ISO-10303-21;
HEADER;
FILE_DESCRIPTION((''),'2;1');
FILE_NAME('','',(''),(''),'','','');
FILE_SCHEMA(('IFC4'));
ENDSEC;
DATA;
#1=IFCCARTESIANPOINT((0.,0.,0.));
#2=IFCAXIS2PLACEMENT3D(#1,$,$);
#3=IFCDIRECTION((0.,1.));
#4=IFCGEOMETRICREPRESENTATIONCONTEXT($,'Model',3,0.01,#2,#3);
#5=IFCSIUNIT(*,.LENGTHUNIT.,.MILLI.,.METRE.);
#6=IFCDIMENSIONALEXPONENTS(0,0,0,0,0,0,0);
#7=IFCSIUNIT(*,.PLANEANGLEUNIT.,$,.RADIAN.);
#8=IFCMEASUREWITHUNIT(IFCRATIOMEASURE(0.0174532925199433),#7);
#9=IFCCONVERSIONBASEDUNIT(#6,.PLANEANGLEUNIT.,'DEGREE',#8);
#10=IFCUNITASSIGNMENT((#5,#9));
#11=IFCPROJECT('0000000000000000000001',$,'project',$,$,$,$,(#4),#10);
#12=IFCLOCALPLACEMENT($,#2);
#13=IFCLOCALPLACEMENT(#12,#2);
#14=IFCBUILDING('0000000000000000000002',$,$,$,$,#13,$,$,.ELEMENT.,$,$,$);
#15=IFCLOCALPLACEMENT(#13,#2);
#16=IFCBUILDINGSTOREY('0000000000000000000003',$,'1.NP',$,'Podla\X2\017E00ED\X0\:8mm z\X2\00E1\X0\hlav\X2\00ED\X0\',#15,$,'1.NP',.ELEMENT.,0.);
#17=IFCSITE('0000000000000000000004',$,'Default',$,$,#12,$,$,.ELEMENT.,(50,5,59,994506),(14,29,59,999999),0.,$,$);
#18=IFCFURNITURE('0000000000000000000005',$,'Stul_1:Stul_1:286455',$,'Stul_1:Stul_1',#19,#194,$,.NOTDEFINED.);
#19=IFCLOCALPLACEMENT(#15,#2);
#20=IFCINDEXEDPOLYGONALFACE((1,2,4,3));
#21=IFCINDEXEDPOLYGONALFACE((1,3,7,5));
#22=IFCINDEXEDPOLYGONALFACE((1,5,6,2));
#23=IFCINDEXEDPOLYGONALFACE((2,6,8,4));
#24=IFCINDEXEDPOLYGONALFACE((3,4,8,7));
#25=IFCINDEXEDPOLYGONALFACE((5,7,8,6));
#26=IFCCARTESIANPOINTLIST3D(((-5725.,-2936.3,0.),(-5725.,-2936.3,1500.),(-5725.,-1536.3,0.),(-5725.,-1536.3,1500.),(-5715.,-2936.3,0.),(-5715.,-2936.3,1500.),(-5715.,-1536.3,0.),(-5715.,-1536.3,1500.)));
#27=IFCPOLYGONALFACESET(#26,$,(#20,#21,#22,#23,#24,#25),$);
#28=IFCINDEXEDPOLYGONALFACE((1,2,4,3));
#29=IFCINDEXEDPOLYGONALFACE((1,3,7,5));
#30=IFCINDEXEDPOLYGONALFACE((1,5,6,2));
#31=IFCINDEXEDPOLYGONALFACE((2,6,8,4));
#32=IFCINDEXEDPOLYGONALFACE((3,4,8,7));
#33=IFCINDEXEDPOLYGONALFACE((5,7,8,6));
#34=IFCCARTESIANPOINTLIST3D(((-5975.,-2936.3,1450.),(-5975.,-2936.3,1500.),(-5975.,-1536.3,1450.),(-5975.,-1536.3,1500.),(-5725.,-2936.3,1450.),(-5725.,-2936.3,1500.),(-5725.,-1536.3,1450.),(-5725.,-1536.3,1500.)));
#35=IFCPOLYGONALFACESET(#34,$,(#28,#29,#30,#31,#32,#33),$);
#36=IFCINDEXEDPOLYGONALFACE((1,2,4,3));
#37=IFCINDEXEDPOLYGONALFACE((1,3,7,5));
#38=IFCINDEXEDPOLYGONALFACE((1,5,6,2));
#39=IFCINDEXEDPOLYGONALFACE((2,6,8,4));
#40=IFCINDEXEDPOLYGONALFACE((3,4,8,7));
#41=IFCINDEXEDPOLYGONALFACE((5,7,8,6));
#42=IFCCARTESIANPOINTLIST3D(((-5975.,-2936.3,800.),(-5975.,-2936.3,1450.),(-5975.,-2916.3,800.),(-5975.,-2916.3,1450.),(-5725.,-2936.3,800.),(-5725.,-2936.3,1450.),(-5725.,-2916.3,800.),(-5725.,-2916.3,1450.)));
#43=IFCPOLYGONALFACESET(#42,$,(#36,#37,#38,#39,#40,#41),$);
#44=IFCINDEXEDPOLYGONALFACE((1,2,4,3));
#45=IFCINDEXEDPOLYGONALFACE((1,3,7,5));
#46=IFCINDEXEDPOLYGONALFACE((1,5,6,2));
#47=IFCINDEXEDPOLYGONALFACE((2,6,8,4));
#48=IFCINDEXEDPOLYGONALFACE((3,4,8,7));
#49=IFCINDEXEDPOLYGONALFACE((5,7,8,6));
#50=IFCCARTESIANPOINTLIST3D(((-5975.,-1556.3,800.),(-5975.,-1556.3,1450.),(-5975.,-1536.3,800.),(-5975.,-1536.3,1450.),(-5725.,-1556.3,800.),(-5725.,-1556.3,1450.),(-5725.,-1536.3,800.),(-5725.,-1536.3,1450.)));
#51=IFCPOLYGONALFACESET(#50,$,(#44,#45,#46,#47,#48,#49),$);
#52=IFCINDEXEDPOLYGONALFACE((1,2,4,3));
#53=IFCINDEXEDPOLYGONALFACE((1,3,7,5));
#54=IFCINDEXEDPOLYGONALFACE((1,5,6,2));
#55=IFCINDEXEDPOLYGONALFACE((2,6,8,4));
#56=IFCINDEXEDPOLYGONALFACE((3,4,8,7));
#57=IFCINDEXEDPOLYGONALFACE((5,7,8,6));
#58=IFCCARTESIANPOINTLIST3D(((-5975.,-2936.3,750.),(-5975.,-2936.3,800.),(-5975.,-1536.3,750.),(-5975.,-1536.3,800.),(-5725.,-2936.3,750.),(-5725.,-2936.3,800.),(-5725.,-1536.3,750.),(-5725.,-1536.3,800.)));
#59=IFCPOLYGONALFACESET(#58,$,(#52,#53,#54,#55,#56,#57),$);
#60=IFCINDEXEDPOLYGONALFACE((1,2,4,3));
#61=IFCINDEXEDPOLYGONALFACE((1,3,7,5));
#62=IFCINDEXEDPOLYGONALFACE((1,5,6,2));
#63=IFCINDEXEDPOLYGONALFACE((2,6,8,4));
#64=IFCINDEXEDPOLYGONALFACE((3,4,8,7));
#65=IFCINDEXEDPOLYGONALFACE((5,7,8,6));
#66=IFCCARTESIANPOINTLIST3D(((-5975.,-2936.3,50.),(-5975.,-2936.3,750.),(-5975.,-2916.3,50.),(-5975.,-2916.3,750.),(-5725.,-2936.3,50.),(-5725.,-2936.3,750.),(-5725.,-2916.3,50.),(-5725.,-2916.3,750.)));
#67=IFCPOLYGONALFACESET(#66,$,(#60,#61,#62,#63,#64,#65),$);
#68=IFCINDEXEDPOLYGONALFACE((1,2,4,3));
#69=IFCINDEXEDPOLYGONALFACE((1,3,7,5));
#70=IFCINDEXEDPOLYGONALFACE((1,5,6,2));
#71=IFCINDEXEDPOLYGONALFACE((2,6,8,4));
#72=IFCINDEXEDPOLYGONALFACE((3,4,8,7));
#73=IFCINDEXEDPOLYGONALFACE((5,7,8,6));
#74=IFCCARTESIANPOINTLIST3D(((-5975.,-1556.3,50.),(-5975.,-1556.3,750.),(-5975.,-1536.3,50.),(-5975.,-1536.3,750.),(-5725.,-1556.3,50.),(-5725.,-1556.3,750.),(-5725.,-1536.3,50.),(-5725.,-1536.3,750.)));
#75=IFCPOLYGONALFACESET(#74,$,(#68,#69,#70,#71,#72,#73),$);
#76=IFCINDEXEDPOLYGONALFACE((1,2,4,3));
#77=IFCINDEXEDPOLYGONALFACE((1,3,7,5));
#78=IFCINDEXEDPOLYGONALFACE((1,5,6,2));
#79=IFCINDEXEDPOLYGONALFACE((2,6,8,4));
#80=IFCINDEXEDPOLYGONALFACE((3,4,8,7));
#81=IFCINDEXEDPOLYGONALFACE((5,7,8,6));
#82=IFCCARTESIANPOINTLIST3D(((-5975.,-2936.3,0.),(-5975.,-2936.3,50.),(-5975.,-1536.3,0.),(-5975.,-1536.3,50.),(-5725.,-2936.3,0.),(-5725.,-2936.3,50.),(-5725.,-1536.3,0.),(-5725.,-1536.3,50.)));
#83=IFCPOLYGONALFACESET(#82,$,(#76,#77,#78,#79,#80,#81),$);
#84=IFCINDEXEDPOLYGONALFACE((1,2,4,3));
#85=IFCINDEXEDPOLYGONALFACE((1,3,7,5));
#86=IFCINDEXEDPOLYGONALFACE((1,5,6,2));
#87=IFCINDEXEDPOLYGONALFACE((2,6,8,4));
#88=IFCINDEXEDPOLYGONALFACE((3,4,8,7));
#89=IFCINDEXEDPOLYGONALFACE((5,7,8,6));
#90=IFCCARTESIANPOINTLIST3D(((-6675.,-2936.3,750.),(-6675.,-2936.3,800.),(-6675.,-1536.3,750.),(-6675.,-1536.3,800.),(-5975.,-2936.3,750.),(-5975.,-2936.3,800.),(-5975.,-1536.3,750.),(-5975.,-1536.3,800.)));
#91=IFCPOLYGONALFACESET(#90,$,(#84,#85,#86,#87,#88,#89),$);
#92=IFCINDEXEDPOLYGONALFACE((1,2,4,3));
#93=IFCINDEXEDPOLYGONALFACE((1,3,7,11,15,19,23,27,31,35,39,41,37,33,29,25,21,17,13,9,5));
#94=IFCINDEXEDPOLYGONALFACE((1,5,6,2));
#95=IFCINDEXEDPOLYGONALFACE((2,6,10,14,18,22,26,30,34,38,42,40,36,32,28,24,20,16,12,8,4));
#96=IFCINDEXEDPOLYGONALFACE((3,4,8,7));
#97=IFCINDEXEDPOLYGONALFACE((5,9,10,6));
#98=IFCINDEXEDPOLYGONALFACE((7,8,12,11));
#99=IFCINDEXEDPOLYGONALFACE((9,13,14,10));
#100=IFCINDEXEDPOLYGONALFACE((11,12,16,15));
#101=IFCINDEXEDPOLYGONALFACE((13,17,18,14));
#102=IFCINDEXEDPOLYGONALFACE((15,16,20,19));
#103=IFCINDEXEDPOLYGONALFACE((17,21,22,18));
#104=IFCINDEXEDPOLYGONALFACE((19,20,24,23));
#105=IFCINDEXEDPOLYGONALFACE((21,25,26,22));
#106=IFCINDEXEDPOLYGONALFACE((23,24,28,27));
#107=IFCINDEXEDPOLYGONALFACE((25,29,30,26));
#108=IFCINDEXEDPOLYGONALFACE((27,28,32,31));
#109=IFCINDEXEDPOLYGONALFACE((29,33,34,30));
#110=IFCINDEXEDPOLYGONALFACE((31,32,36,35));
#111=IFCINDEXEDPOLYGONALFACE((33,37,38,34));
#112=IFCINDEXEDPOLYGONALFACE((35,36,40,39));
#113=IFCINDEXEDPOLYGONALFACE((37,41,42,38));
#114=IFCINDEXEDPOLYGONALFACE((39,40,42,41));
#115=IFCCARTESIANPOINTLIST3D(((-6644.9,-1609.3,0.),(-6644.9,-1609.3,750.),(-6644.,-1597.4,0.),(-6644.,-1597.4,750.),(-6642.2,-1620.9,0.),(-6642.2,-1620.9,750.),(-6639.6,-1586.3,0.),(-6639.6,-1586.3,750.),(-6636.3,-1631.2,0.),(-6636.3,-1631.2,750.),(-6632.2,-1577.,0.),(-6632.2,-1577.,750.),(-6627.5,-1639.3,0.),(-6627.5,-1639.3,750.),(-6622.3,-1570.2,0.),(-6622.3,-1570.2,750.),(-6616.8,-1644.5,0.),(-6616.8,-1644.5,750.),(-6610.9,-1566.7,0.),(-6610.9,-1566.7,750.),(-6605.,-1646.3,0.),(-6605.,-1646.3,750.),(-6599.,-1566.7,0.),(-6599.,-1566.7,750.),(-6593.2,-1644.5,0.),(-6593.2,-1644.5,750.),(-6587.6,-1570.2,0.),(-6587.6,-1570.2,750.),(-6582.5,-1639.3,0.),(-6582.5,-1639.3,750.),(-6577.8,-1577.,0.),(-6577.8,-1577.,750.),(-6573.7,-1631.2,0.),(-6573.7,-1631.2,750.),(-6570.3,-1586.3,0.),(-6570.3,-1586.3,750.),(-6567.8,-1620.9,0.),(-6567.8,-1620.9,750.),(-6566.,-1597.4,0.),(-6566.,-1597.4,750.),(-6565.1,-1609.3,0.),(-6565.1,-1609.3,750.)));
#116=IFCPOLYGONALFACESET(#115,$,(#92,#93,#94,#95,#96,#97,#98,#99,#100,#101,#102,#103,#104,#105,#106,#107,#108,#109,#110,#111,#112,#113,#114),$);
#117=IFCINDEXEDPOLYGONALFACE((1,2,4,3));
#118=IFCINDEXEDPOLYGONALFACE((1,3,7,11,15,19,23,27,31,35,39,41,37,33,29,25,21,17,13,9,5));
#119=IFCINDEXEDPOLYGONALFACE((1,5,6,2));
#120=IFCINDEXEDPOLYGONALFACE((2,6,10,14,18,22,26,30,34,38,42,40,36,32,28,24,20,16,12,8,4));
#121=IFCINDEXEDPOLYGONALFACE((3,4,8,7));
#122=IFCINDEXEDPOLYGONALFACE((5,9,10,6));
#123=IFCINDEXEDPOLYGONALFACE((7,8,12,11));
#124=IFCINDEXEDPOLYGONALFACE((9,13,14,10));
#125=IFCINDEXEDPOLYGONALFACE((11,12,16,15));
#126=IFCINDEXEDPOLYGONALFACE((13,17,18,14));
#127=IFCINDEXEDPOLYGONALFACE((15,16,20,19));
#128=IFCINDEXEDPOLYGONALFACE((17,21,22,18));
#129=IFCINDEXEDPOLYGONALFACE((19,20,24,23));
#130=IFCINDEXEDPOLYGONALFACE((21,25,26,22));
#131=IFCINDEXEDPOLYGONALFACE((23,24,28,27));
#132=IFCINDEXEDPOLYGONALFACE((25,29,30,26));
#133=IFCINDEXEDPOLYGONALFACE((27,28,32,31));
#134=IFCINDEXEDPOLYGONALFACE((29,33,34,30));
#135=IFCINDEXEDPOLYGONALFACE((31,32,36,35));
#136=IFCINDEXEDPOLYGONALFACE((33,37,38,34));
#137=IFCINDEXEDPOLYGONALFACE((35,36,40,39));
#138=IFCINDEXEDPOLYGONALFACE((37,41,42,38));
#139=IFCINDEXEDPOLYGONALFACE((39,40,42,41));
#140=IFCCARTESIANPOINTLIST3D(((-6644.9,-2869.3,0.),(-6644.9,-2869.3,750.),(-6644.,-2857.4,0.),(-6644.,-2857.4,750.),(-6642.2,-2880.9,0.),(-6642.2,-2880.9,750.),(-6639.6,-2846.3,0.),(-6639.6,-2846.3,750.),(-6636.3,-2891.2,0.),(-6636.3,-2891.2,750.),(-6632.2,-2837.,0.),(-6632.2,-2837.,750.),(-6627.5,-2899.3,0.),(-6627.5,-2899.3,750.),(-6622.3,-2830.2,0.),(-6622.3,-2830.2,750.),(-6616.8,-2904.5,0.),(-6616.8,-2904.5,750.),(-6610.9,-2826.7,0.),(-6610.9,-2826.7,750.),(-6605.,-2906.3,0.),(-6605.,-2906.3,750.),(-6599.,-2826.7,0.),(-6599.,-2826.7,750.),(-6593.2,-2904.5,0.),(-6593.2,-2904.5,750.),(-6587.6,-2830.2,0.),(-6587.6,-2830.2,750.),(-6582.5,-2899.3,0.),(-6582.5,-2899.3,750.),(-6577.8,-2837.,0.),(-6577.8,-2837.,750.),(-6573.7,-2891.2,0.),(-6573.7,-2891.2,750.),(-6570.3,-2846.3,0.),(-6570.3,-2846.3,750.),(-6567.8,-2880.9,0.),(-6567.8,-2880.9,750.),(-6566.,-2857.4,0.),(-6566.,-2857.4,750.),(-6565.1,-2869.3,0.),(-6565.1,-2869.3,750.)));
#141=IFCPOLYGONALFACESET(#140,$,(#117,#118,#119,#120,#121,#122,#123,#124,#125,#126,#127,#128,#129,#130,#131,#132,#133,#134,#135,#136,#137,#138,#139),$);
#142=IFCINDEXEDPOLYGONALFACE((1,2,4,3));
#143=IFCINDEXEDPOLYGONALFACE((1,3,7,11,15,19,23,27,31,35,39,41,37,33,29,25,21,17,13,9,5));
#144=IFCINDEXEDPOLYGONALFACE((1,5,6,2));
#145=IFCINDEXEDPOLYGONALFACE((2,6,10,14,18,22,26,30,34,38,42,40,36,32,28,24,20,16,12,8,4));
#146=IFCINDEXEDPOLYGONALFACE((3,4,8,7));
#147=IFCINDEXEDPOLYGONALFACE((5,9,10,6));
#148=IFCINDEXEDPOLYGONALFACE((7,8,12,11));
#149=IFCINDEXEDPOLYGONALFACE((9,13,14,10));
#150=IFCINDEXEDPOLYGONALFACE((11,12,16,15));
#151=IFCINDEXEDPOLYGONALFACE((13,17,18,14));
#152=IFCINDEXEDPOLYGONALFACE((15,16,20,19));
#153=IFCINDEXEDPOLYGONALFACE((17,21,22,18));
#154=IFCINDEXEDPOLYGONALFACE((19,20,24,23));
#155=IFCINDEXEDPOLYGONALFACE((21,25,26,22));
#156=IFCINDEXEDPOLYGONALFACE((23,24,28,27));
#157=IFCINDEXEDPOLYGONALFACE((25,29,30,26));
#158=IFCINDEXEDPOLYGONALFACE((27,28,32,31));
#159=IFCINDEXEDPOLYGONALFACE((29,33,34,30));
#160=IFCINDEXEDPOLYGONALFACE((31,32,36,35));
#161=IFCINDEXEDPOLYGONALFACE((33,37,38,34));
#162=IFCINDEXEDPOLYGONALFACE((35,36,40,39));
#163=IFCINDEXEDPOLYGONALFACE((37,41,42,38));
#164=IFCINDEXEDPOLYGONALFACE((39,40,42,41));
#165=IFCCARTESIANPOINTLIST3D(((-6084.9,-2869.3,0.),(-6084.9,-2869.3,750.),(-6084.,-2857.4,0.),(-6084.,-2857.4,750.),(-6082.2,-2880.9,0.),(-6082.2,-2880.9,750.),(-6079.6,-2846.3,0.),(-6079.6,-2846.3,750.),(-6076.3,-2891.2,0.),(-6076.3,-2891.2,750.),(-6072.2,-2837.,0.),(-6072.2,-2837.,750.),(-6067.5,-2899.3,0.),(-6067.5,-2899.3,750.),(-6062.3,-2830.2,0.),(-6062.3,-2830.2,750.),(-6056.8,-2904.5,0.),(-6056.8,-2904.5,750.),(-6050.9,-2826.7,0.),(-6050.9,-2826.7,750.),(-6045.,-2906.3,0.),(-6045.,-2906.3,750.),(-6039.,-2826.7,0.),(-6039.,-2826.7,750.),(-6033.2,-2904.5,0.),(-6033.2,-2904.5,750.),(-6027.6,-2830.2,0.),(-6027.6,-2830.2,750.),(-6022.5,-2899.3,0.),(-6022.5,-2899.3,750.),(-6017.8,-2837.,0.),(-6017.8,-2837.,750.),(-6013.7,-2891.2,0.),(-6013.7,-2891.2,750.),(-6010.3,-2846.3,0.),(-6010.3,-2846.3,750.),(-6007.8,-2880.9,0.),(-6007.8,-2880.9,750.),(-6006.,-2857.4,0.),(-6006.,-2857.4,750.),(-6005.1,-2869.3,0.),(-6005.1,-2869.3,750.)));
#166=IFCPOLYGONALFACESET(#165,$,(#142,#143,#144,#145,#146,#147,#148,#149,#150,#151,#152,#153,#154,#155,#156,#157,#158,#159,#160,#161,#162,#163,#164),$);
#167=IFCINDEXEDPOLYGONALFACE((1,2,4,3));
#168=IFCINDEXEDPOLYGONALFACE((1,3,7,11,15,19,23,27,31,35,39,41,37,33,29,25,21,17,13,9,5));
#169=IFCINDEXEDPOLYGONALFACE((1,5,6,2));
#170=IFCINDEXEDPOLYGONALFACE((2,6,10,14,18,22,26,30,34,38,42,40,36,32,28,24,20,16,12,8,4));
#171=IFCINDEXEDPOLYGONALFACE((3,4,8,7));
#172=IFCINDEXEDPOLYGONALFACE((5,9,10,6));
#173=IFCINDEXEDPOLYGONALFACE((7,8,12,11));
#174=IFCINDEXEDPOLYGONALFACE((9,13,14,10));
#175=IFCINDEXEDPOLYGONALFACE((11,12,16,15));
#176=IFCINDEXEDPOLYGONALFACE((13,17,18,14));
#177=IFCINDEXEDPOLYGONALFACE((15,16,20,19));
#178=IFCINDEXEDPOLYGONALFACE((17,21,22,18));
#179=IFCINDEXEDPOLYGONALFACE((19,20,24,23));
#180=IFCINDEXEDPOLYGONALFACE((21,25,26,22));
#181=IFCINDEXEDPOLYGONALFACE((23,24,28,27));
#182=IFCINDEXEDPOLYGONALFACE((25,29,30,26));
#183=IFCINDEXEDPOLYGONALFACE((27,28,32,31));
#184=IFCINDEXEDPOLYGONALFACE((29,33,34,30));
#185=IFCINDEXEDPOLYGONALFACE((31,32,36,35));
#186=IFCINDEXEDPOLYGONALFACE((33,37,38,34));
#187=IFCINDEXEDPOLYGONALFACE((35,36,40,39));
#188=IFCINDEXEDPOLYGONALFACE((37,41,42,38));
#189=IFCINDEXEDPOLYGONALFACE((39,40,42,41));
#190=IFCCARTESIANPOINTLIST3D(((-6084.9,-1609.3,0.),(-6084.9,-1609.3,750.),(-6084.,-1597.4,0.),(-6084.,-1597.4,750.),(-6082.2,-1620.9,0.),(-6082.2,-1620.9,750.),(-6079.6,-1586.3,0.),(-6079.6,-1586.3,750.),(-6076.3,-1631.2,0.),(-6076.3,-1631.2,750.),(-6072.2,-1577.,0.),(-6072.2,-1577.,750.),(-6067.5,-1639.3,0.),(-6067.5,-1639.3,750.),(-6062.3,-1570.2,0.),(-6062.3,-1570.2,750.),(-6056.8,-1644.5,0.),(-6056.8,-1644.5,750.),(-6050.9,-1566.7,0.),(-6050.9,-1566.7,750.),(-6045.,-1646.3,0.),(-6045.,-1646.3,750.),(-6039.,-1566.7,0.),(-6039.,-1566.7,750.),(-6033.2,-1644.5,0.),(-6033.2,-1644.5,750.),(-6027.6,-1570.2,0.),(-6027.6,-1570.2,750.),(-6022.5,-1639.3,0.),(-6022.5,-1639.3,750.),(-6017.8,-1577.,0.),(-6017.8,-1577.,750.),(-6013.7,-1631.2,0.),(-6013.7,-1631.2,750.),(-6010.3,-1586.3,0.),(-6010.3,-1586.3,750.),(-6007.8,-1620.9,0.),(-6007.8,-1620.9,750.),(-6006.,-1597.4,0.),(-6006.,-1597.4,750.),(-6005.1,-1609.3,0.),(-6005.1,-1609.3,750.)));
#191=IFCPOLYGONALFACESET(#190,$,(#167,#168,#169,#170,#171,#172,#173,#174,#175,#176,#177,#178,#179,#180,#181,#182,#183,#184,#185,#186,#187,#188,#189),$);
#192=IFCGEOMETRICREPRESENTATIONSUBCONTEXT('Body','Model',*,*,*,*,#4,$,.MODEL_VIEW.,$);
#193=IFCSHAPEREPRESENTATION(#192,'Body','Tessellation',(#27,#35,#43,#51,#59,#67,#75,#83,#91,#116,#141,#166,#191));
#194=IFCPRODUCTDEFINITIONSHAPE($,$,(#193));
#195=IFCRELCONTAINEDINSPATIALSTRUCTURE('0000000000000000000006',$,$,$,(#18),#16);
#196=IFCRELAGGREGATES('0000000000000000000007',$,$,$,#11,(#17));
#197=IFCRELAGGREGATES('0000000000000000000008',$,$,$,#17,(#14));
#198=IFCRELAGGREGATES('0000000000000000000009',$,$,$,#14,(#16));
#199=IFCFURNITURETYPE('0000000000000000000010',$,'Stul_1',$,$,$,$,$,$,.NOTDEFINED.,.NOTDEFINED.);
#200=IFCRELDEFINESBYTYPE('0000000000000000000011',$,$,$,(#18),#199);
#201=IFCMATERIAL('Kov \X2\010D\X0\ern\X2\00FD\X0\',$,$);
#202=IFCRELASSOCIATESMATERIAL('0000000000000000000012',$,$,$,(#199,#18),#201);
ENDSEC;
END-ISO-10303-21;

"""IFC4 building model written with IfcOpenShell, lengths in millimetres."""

from ifc_helpers import new_model, entity, si_unit, converted_unit, direction, frame, frame_2d, origin, origin_2d_with_axis, place, context, subcontext, project, spatial, rectangle, circle, extrude, source, transform, mapped, material, type_object, type_shapes, element, save


model = new_model("IFC4")

# Units and contexts
model_context = context("Model", 3, precision=0.01, world=origin(), true_north=direction((0.0, 1.0)))
body_context = subcontext(model_context, "Body", "Model", "MODEL_VIEW")
ifc_project = project(units=[si_unit("LENGTHUNIT", "METRE", prefix="MILLI"), converted_unit("PLANEANGLEUNIT", "DEGREE", entity("IfcRatioMeasure", 0.0174532925199433), si_unit("PLANEANGLEUNIT", "RADIAN"), dimensions=[0, 0, 0, 0, 0, 0, 0])], contexts=[model_context])

# Site, building, storey
site_placement = place(None, origin())
site = spatial("IfcSite", under=ifc_project, at=site_placement, Name="Default", CompositionType="ELEMENT", RefLatitude=(50, 5, 59, 994506), RefLongitude=(14, 29, 59, 999999), RefElevation=0.0)
building_placement = place(site_placement, origin())
building = spatial("IfcBuilding", under=site, at=building_placement, CompositionType="ELEMENT")
storey_placement = place(building_placement, origin())
storey = spatial("IfcBuildingStorey", under=building, at=storey_placement, Name="1.NP", ObjectType="Podlaží:8mm záhlaví", LongName="1.NP", CompositionType="ELEMENT", Elevation=0.0)

# Furniture
ifc_material_1 = material(Name="Kov černý")
furniture_type = type_object("IfcFurnitureType", Name="Stul_1", AssemblyPlace="NOTDEFINED", PredefinedType="NOTDEFINED", material=ifc_material_1)
shared_shape_1 = source(origin(), body_context, "Body", "SweptSolid", [
    extrude(rectangle(XDim=1400.0, YDim=10.0, at=origin_2d_with_axis()), frame((0.0, 605.0, 0.0), z_axis=(0.0, 0.0, 1.0), x_axis=(-1.0, 0.0, 0.0)), (0.0, 0.0, 1.0), 1500.0),
    extrude(rectangle(XDim=1400.0, YDim=250.0, at=frame_2d((0.0, 0.0), x_axis=(1.0, 0.0))), frame((0.0, 475.0, 1450.0), z_axis=(0.0, 0.0, 1.0), x_axis=(-1.0, 0.0, 0.0)), (0.0, 0.0, 1.0), 50.0),
    extrude(rectangle(XDim=20.0, YDim=250.0, at=origin_2d_with_axis()), frame((690.0, 475.0, 800.0), z_axis=(0.0, 0.0, 1.0), x_axis=(-1.0, 0.0, 0.0)), (0.0, 0.0, 1.0), 650.0),
    extrude(rectangle(XDim=20.0, YDim=250.0, at=frame_2d((0.0, 0.0), x_axis=(1.0, 0.0))), frame((-690.0, 475.0, 800.0), z_axis=(0.0, 0.0, 1.0), x_axis=(-1.0, 0.0, 0.0)), (0.0, 0.0, 1.0), 650.0),
    extrude(rectangle(XDim=1400.0, YDim=250.0, at=origin_2d_with_axis()), frame((0.0, 475.0, 750.0), z_axis=(0.0, 0.0, 1.0), x_axis=(-1.0, 0.0, 0.0)), (0.0, 0.0, 1.0), 50.0),
    extrude(rectangle(XDim=20.0, YDim=250.0, at=origin_2d_with_axis()), frame((690.0, 475.0, 50.0), z_axis=(0.0, 0.0, 1.0), x_axis=(-1.0, 0.0, 0.0)), (0.0, 0.0, 1.0), 700.0),
    extrude(rectangle(XDim=20.0, YDim=250.0, at=frame_2d((0.0, 0.0), x_axis=(1.0, 0.0))), frame((-690.0, 475.0, 50.0), z_axis=(0.0, 0.0, 1.0), x_axis=(-1.0, 0.0, 0.0)), (0.0, 0.0, 1.0), 700.0),
    extrude(rectangle(XDim=1400.0, YDim=250.0, at=origin_2d_with_axis()), frame((0.0, 475.0, 0.0), z_axis=(0.0, 0.0, 1.0), x_axis=(-1.0, 0.0, 0.0)), (0.0, 0.0, 1.0), 50.0),
    extrude(rectangle(XDim=1400.0, YDim=700.0, at=origin_2d_with_axis()), frame((0.0, 0.0, 750.0), z_axis=(0.0, 0.0, 1.0), x_axis=(-1.0, 0.0, 0.0)), (0.0, 0.0, 1.0), 50.0),
    extrude(circle(Radius=40.0, at=frame_2d((0.0, 0.0), x_axis=(1.0, 0.0))), frame((-630.0, -280.0, 0.0)), (0.0, 0.0, 1.0), 750.0),
    extrude(circle(Radius=40.0, at=frame_2d((0.0, 0.0), x_axis=(1.0, 0.0))), frame((630.0, -280.0, 0.0)), (0.0, 0.0, 1.0), 750.0),
    extrude(circle(Radius=40.0, at=frame_2d((0.0, 0.0), x_axis=(1.0, 0.0))), frame((630.0, 280.0, 0.0)), (0.0, 0.0, 1.0), 750.0),
    extrude(circle(Radius=40.0, at=frame_2d((0.0, 0.0), x_axis=(1.0, 0.0))), frame((-630.0, 280.0, 0.0)), (0.0, 0.0, 1.0), 750.0),
])
type_shapes(furniture_type, [shared_shape_1])
for number, where, z_axis, x_axis, name in (
    (1, (-6325.0, -2236.3, 0.0), (0.0, 0.0, 1.0), (0.0, -1.0, 0.0), "Stul_1:Stul_1:286455"),
):
    element("IfcFurniture", number, at=place(storey_placement, frame(where, z_axis=z_axis, x_axis=x_axis)), inside=storey, type_object=furniture_type, material=ifc_material_1, Name=name, ObjectType="Stul_1:Stul_1", PredefinedType="NOTDEFINED", context=body_context, shape_type="MappedRepresentation", body=[
        mapped(shared_shape_1, transform((0.0, 0.0, 0.0), scale=1.0)),
    ])

save(model, "model.ifc")
